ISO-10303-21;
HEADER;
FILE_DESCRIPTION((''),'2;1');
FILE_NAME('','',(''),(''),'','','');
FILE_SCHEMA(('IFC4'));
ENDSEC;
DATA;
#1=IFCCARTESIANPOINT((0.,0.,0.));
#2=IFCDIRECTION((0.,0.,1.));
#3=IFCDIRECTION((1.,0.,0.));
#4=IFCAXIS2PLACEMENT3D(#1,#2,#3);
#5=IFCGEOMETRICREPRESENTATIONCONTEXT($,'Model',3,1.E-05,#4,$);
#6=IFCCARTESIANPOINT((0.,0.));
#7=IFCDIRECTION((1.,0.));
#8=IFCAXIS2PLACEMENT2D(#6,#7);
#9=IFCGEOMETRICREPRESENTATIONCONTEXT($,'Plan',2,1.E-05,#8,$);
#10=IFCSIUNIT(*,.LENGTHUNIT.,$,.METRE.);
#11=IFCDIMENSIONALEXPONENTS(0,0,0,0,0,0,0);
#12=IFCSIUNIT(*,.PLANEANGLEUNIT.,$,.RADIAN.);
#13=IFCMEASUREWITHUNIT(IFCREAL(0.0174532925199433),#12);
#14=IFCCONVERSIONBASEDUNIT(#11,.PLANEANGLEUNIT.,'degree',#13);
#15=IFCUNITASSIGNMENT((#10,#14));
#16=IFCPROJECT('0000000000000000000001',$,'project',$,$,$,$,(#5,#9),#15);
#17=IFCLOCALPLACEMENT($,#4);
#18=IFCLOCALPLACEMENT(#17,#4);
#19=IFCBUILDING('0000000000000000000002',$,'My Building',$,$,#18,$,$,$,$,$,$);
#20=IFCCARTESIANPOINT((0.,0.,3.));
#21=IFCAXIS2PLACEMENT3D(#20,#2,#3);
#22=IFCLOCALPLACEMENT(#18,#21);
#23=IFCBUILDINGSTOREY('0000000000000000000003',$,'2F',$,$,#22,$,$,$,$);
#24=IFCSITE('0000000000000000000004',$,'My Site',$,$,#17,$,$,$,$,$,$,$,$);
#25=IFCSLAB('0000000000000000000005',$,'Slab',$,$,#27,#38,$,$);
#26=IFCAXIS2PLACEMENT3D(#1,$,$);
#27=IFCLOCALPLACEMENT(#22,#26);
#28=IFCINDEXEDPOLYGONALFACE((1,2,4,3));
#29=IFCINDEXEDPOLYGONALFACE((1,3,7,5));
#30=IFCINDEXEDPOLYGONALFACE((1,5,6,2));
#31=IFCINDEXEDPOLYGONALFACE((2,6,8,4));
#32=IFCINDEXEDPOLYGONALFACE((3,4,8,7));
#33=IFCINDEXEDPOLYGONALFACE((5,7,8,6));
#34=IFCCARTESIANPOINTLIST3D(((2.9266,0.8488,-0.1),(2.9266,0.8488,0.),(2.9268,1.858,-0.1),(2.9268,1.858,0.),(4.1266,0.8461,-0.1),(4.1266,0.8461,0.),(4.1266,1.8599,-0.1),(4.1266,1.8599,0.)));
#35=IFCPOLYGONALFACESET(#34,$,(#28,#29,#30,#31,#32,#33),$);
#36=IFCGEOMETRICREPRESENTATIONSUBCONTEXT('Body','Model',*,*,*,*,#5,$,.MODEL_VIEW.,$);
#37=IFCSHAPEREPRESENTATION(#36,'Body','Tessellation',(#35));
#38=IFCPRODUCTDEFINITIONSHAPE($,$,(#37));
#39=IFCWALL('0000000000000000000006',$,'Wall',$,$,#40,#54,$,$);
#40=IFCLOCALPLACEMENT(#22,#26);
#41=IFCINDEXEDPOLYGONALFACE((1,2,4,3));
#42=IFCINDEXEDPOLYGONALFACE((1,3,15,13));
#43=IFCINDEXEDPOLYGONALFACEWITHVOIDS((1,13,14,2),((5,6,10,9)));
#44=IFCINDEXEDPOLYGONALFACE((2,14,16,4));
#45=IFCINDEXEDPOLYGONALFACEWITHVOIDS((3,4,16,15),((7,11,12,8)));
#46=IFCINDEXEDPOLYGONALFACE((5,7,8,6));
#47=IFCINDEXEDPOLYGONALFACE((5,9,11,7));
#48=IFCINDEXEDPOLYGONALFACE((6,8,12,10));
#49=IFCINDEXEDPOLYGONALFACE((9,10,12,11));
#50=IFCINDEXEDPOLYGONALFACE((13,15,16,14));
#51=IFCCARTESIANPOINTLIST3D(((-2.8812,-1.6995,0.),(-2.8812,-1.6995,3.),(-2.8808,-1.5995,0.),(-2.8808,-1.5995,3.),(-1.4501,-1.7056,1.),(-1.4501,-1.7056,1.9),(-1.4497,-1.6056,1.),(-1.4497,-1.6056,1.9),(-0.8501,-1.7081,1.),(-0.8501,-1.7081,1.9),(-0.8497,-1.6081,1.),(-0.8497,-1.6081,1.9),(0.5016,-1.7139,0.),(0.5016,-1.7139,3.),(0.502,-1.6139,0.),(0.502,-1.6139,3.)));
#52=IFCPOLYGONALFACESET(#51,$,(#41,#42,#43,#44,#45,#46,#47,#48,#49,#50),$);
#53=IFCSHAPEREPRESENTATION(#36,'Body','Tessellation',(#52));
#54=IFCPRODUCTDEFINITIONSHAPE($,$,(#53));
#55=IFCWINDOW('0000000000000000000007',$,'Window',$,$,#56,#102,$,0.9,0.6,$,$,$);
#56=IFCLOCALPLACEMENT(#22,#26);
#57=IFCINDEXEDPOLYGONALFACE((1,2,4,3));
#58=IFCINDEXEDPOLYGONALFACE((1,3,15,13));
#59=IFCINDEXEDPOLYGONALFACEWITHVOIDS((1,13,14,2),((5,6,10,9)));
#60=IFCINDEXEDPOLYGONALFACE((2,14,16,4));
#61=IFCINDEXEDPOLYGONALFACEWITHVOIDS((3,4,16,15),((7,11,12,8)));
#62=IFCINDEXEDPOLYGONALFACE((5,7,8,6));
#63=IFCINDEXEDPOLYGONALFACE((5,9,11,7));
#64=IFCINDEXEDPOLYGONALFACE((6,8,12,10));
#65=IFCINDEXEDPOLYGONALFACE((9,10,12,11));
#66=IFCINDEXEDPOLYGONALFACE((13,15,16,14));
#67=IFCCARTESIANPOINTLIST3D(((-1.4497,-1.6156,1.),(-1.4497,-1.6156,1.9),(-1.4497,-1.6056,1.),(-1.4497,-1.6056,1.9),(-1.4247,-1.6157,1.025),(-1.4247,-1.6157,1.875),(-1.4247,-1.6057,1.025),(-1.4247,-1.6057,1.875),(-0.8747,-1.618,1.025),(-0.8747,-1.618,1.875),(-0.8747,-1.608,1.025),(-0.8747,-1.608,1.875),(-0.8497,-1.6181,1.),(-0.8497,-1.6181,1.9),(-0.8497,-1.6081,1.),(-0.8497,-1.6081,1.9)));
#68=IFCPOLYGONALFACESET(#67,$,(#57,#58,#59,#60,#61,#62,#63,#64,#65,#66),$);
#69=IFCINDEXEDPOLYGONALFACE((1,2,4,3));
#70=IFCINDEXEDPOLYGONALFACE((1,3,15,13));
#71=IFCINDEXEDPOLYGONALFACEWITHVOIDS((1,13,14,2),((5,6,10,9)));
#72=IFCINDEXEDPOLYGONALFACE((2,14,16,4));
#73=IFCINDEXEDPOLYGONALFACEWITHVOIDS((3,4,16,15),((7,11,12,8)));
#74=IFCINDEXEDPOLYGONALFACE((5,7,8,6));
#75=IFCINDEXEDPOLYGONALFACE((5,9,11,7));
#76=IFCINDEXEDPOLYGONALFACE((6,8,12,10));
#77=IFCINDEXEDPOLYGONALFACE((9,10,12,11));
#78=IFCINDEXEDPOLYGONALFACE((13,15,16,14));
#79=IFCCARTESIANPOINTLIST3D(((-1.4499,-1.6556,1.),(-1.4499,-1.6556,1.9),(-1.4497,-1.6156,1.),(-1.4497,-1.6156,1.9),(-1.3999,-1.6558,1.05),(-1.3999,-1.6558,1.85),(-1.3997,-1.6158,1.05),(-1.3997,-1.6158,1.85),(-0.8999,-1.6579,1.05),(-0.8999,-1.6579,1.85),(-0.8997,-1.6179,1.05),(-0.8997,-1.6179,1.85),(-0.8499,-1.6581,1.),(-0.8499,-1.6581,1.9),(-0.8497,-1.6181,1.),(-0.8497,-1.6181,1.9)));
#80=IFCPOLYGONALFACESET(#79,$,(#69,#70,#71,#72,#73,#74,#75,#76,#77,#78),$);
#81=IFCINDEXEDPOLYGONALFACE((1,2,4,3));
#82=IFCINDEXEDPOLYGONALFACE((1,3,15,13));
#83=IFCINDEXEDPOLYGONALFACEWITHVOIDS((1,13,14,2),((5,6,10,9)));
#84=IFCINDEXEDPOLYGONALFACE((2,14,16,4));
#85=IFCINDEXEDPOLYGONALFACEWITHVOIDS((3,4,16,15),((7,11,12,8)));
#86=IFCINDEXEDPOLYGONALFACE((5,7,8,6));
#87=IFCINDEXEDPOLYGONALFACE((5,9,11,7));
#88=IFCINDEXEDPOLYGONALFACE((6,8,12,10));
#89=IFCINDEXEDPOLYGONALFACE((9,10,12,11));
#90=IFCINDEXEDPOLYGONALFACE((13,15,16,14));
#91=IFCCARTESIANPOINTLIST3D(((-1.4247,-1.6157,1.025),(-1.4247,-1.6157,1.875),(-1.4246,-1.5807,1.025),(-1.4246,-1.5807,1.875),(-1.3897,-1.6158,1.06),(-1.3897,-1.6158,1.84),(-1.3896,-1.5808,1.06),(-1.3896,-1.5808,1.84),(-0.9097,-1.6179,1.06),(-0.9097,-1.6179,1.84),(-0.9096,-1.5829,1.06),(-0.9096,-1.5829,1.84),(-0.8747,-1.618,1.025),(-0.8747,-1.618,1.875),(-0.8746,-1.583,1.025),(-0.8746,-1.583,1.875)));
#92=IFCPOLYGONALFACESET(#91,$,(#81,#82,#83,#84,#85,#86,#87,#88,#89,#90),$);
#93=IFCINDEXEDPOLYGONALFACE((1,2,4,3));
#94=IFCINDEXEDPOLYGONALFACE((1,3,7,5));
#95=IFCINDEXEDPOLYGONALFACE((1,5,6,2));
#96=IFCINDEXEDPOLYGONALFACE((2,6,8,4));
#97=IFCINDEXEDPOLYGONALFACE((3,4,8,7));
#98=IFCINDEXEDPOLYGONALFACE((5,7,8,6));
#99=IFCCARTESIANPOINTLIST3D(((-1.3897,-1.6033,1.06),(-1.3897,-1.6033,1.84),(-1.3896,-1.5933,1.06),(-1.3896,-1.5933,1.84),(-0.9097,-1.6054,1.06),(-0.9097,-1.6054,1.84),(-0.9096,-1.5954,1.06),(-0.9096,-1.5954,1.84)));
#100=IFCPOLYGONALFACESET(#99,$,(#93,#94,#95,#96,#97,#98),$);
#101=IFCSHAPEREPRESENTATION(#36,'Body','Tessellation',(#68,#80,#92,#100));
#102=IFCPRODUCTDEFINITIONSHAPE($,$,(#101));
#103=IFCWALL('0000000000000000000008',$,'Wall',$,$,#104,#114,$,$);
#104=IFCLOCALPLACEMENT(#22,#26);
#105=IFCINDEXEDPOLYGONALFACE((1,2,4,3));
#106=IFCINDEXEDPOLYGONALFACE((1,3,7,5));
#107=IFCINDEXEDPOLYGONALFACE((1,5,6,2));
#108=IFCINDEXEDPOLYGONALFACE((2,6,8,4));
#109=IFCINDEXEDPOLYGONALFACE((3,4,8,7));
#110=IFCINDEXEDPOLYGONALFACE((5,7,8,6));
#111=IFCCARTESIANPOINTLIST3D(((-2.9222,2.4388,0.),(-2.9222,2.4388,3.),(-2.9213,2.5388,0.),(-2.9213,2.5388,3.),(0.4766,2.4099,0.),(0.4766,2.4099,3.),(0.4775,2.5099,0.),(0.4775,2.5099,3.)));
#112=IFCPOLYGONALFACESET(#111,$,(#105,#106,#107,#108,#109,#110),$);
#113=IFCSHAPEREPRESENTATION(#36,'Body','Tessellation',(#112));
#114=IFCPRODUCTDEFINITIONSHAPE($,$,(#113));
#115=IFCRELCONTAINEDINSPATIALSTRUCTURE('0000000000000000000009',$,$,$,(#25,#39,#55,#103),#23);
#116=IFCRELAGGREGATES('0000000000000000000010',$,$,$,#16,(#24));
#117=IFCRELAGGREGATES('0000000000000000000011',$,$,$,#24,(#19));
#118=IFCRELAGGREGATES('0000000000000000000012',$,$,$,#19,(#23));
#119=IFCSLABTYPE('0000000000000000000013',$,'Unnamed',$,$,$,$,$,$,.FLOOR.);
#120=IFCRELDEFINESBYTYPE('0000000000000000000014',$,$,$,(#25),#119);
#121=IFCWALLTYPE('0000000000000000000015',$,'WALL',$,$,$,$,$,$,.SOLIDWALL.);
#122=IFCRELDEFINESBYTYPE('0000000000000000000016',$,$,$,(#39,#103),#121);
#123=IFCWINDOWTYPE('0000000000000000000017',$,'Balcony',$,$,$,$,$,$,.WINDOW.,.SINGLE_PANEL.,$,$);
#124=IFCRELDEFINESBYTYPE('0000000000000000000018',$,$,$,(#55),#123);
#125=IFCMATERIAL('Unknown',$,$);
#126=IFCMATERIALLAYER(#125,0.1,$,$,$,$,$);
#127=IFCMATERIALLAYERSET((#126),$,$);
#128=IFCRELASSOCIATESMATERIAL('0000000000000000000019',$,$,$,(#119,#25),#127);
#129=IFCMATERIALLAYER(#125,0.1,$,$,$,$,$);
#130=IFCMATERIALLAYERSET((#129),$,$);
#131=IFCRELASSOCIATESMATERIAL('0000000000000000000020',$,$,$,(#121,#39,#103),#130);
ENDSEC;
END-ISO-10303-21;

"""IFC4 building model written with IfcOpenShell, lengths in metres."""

from ifc_helpers import new_model, entity, si_unit, converted_unit, frame, origin_with_axes, origin_2d_with_axis, place, context, subcontext, project, spatial, line, indexed_curve, outline, extrude, shape, source, transform, mapped, material, layer, layer_set, layer_usage, type_object, type_shapes, element, fill, save


model = new_model("IFC4")

# Units and contexts
model_context = context("Model", 3, precision=1e-05, world=origin_with_axes())
plan_context = context("Plan", 2, precision=1e-05, world=origin_2d_with_axis())
body_context_1 = subcontext(model_context, "Body", "Model", "MODEL_VIEW")
body_context_2 = subcontext(plan_context, "Body", "Plan", "PLAN_VIEW")
ifc_project = project(units=[si_unit("LENGTHUNIT", "METRE"), converted_unit("PLANEANGLEUNIT", "degree", entity("IfcReal", 0.0174532925199433), si_unit("PLANEANGLEUNIT", "RADIAN"), dimensions=[0, 0, 0, 0, 0, 0, 0])], contexts=[model_context, plan_context])

# Site, building, storey
site_placement = place(None, origin_with_axes())
site = spatial("IfcSite", under=ifc_project, at=site_placement, Name="My Site")
building_placement = place(site_placement, origin_with_axes())
building = spatial("IfcBuilding", under=site, at=building_placement, Name="My Building")
storey_placement = place(building_placement, frame((0.0, 0.0, 3.0), z_axis=(0.0, 0.0, 1.0), x_axis=(1.0, 0.0, 0.0)))
storey = spatial("IfcBuildingStorey", under=building, at=storey_placement, Name="2F")

# Slab
ifc_material = material(Name="Unknown")
ifc_layer_1 = layer(ifc_material, 0.1)
ifc_layer_set_1 = layer_set([ifc_layer_1])
ifc_layer_usage_1 = layer_usage(ifc_layer_set_1, "AXIS3", "POSITIVE", -0.1)
slab_type = type_object("IfcSlabType", Name="Unnamed", PredefinedType="FLOOR", material=ifc_layer_set_1)
slab_placement = place(storey_placement, frame((2.9266, 0.8488, 0.0), z_axis=(0.0, 0.0, 1.0), x_axis=(1.0, 0.0, 0.0)))
element("IfcSlab", 1, at=slab_placement, inside=storey, type_object=slab_type, material=ifc_layer_usage_1, Name="Slab", context=body_context_1, shape_type="SweptSolid", body=[
    extrude(outline(indexed_curve([(0.0, 0.0), (1.2, -0.0027), (1.2, 1.0111), (0.0002, 1.0092), (0.0, 0.0)])), frame((0.0, 0.0, -0.1), z_axis=(0.0, 0.0, 1.0), x_axis=(1.0, 0.0, 0.0)), (0.0, 0.0, 1.0), 0.1),
])

# Wall, opening, window
ifc_layer_2 = layer(ifc_material, 0.1)
ifc_layer_set_2 = layer_set([ifc_layer_2])
ifc_layer_usage_2 = layer_usage(ifc_layer_set_2, "AXIS2", "POSITIVE", 0.0)
wall_type = type_object("IfcWallType", Name="WALL", PredefinedType="SOLIDWALL", material=ifc_layer_set_2)
wall_1_placement = place(storey_placement, frame((-2.8812, -1.6995, 0.0), z_axis=(0.0, 0.0, 1.0), x_axis=(0.999991, -0.004277, 0.0)))
wall_1 = element("IfcWall", 2, at=wall_1_placement, inside=storey, type_object=wall_type, material=ifc_layer_usage_2, Name="Wall", context=body_context_1, shape_type="SweptSolid", body=[
    extrude(outline(indexed_curve([(0.0, 0.0), (0.0, 0.1), (3.3828, 0.1), (3.3828, 0.0)], segments=[line(1, 2, 3, 4, 1)])), origin_with_axes(), (0.0, 0.0, 1.0), 3.0),
])
shared_shape_1 = source(origin_with_axes(), body_context_1, "Body", "SweptSolid", [
    extrude(outline(indexed_curve([(0.0, 0.0), (0.6, 0.0), (0.6, 0.9), (0.0, 0.9)], segments=[line(1, 2, 3, 4, 1)])), frame((0.0, -0.6, 0.0), z_axis=(0.0, -1.0, 0.0), x_axis=(1.0, 0.0, 0.0)), (0.0, 0.0, -1.0), 1.2),
])
opening_1_placement = place(wall_1_placement, frame((1.4311, 0.0, 1.0), z_axis=(0.0, 0.0, 1.0), x_axis=(1.0, 0.0, 0.0)))
opening_1 = element("IfcOpeningElement", 3, at=opening_1_placement, cuts=wall_1, PredefinedType="OPENING", context=body_context_1, shape_type="MappedRepresentation", body=[
    mapped(shared_shape_1, transform((0.0, 0.0, 0.0), x_axis=(1.0, 0.0, 0.0), y_axis=(0.0, 1.0, 0.0), z_axis=(0.0, 0.0, 1.0), scale=1.0)),
])
window_type = type_object("IfcWindowType", Name="Balcony", PartitioningType="SINGLE_PANEL", PredefinedType="WINDOW")
shared_shape_2 = source(origin_with_axes(), body_context_1, "Body", "SweptSolid", [
    extrude(outline(indexed_curve([(0.0, 0.0), (0.6, 0.0), (0.6, 0.9), (0.0, 0.9)], segments=[line(1, 2, 3, 4, 1)]), holes=[indexed_curve([(0.025, 0.025), (0.575, 0.025), (0.575, 0.875), (0.025, 0.875)], segments=[line(1, 2, 3, 4, 1)])]), frame((0.0, 0.09, 0.0), z_axis=(0.0, -1.0, 0.0), x_axis=(1.0, 0.0, 0.0)), (0.0, 0.0, -1.0), 0.01),
    extrude(outline(indexed_curve([(0.0, 0.0), (0.6, 0.0), (0.6, 0.9), (0.0, 0.9)], segments=[line(1, 2, 3, 4, 1)]), holes=[indexed_curve([(0.05, 0.05), (0.55, 0.05), (0.55, 0.85), (0.05, 0.85)], segments=[line(1, 2, 3, 4, 1)])]), frame((0.0, 0.05, 0.0), z_axis=(0.0, -1.0, 0.0), x_axis=(1.0, 0.0, 0.0)), (0.0, 0.0, -1.0), 0.04),
    extrude(outline(indexed_curve([(0.0, 0.0), (0.55, 0.0), (0.55, 0.85), (0.0, 0.85)], segments=[line(1, 2, 3, 4, 1)]), holes=[indexed_curve([(0.035, 0.035), (0.515, 0.035), (0.515, 0.815), (0.035, 0.815)], segments=[line(1, 2, 3, 4, 1)])]), frame((0.025, 0.09, 0.025), z_axis=(0.0, -1.0, 0.0), x_axis=(1.0, 0.0, 0.0)), (0.0, 0.0, -1.0), 0.035),
    extrude(outline(indexed_curve([(0.035, 0.035), (0.515, 0.035), (0.515, 0.815), (0.035, 0.815)], segments=[line(1, 2, 3, 4, 1)])), frame((0.025, 0.1025, 0.025), z_axis=(0.0, -1.0, 0.0), x_axis=(1.0, 0.0, 0.0)), (0.0, 0.0, -1.0), 0.01),
])
shared_shape_3 = source(origin_with_axes(), body_context_2, "Body", "Curve2D", [
    entity("IfcIndexedPolyCurve", entity("IfcCartesianPointList2D", [[0.05, 0.05], [0.55, 0.05]])),
    entity("IfcIndexedPolyCurve", entity("IfcCartesianPointList2D", [[0.0, 0.1], [0.025, 0.1], [0.025, 0.09], [0.05, 0.09], [0.05, 0.05], [0.0, 0.05]]), [entity("IfcLineIndex", [1, 2, 3, 4, 5, 6, 1])]),
    entity("IfcIndexedPolyCurve", entity("IfcCartesianPointList2D", [[0.6, 0.1], [0.575, 0.1], [0.575, 0.09], [0.55, 0.09], [0.55, 0.05], [0.6, 0.05]]), [entity("IfcLineIndex", [1, 2, 3, 4, 5, 6, 1])]),
    entity("IfcIndexedPolyCurve", entity("IfcCartesianPointList2D", [[0.025, 0.09], [0.06, 0.09], [0.06, 0.125], [0.025, 0.125]]), [entity("IfcLineIndex", [1, 2, 3, 4, 1])]),
    entity("IfcIndexedPolyCurve", entity("IfcCartesianPointList2D", [[0.575, 0.09], [0.54, 0.09], [0.54, 0.125], [0.575, 0.125]]), [entity("IfcLineIndex", [1, 2, 3, 4, 1])]),
    entity("IfcIndexedPolyCurve", entity("IfcCartesianPointList2D", [[0.06, 0.09], [0.54, 0.09]])),
    entity("IfcIndexedPolyCurve", entity("IfcCartesianPointList2D", [[0.06, 0.125], [0.54, 0.125]])),
    entity("IfcIndexedPolyCurve", entity("IfcCartesianPointList2D", [[0.06, 0.1075], [0.54, 0.1075]])),
])
type_shapes(window_type, [shared_shape_2, shared_shape_3])
window_placement = place(opening_1_placement, frame((0.0, 0.0, 0.0), z_axis=(0.0, 0.0, 1.0), x_axis=(1.0, 0.0, 0.0)))
window = element("IfcWindow", 4, at=window_placement, inside=storey, type_object=window_type, Name="Window", OverallHeight=0.9, OverallWidth=0.6, shapes=[
    shape(body_context_1, "Body", "MappedRepresentation", [mapped(shared_shape_2, transform((0.0, 0.0, 0.0), x_axis=(1.0, 0.0, 0.0), y_axis=(0.0, 1.0, 0.0), z_axis=(0.0, 0.0, 1.0), scale=1.0))]),
    shape(body_context_2, "Body", "MappedRepresentation", [mapped(shared_shape_3, transform((0.0, 0.0, 0.0), x_axis=(1.0, 0.0, 0.0), y_axis=(0.0, 1.0, 0.0), z_axis=(0.0, 0.0, 1.0), scale=1.0))]),
])
fill(opening_1, window)

# Wall
ifc_layer_usage_3 = layer_usage(ifc_layer_set_2, "AXIS2", "POSITIVE", 0.0)
wall_2_placement = place(storey_placement, frame((-2.9222, 2.4388, 0.0), z_axis=(0.0, 0.0, 1.0), x_axis=(0.999964, -0.008491, 0.0)))
element("IfcWall", 5, at=wall_2_placement, inside=storey, type_object=wall_type, material=ifc_layer_usage_3, Name="Wall", context=body_context_1, shape_type="SweptSolid", body=[
    extrude(outline(indexed_curve([(0.0, 0.0), (0.0, 0.1), (3.3989, 0.1), (3.3989, 0.0)], segments=[line(1, 2, 3, 4, 1)])), origin_with_axes(), (0.0, 0.0, 1.0), 3.0),
])

save(model, "model.ifc")
